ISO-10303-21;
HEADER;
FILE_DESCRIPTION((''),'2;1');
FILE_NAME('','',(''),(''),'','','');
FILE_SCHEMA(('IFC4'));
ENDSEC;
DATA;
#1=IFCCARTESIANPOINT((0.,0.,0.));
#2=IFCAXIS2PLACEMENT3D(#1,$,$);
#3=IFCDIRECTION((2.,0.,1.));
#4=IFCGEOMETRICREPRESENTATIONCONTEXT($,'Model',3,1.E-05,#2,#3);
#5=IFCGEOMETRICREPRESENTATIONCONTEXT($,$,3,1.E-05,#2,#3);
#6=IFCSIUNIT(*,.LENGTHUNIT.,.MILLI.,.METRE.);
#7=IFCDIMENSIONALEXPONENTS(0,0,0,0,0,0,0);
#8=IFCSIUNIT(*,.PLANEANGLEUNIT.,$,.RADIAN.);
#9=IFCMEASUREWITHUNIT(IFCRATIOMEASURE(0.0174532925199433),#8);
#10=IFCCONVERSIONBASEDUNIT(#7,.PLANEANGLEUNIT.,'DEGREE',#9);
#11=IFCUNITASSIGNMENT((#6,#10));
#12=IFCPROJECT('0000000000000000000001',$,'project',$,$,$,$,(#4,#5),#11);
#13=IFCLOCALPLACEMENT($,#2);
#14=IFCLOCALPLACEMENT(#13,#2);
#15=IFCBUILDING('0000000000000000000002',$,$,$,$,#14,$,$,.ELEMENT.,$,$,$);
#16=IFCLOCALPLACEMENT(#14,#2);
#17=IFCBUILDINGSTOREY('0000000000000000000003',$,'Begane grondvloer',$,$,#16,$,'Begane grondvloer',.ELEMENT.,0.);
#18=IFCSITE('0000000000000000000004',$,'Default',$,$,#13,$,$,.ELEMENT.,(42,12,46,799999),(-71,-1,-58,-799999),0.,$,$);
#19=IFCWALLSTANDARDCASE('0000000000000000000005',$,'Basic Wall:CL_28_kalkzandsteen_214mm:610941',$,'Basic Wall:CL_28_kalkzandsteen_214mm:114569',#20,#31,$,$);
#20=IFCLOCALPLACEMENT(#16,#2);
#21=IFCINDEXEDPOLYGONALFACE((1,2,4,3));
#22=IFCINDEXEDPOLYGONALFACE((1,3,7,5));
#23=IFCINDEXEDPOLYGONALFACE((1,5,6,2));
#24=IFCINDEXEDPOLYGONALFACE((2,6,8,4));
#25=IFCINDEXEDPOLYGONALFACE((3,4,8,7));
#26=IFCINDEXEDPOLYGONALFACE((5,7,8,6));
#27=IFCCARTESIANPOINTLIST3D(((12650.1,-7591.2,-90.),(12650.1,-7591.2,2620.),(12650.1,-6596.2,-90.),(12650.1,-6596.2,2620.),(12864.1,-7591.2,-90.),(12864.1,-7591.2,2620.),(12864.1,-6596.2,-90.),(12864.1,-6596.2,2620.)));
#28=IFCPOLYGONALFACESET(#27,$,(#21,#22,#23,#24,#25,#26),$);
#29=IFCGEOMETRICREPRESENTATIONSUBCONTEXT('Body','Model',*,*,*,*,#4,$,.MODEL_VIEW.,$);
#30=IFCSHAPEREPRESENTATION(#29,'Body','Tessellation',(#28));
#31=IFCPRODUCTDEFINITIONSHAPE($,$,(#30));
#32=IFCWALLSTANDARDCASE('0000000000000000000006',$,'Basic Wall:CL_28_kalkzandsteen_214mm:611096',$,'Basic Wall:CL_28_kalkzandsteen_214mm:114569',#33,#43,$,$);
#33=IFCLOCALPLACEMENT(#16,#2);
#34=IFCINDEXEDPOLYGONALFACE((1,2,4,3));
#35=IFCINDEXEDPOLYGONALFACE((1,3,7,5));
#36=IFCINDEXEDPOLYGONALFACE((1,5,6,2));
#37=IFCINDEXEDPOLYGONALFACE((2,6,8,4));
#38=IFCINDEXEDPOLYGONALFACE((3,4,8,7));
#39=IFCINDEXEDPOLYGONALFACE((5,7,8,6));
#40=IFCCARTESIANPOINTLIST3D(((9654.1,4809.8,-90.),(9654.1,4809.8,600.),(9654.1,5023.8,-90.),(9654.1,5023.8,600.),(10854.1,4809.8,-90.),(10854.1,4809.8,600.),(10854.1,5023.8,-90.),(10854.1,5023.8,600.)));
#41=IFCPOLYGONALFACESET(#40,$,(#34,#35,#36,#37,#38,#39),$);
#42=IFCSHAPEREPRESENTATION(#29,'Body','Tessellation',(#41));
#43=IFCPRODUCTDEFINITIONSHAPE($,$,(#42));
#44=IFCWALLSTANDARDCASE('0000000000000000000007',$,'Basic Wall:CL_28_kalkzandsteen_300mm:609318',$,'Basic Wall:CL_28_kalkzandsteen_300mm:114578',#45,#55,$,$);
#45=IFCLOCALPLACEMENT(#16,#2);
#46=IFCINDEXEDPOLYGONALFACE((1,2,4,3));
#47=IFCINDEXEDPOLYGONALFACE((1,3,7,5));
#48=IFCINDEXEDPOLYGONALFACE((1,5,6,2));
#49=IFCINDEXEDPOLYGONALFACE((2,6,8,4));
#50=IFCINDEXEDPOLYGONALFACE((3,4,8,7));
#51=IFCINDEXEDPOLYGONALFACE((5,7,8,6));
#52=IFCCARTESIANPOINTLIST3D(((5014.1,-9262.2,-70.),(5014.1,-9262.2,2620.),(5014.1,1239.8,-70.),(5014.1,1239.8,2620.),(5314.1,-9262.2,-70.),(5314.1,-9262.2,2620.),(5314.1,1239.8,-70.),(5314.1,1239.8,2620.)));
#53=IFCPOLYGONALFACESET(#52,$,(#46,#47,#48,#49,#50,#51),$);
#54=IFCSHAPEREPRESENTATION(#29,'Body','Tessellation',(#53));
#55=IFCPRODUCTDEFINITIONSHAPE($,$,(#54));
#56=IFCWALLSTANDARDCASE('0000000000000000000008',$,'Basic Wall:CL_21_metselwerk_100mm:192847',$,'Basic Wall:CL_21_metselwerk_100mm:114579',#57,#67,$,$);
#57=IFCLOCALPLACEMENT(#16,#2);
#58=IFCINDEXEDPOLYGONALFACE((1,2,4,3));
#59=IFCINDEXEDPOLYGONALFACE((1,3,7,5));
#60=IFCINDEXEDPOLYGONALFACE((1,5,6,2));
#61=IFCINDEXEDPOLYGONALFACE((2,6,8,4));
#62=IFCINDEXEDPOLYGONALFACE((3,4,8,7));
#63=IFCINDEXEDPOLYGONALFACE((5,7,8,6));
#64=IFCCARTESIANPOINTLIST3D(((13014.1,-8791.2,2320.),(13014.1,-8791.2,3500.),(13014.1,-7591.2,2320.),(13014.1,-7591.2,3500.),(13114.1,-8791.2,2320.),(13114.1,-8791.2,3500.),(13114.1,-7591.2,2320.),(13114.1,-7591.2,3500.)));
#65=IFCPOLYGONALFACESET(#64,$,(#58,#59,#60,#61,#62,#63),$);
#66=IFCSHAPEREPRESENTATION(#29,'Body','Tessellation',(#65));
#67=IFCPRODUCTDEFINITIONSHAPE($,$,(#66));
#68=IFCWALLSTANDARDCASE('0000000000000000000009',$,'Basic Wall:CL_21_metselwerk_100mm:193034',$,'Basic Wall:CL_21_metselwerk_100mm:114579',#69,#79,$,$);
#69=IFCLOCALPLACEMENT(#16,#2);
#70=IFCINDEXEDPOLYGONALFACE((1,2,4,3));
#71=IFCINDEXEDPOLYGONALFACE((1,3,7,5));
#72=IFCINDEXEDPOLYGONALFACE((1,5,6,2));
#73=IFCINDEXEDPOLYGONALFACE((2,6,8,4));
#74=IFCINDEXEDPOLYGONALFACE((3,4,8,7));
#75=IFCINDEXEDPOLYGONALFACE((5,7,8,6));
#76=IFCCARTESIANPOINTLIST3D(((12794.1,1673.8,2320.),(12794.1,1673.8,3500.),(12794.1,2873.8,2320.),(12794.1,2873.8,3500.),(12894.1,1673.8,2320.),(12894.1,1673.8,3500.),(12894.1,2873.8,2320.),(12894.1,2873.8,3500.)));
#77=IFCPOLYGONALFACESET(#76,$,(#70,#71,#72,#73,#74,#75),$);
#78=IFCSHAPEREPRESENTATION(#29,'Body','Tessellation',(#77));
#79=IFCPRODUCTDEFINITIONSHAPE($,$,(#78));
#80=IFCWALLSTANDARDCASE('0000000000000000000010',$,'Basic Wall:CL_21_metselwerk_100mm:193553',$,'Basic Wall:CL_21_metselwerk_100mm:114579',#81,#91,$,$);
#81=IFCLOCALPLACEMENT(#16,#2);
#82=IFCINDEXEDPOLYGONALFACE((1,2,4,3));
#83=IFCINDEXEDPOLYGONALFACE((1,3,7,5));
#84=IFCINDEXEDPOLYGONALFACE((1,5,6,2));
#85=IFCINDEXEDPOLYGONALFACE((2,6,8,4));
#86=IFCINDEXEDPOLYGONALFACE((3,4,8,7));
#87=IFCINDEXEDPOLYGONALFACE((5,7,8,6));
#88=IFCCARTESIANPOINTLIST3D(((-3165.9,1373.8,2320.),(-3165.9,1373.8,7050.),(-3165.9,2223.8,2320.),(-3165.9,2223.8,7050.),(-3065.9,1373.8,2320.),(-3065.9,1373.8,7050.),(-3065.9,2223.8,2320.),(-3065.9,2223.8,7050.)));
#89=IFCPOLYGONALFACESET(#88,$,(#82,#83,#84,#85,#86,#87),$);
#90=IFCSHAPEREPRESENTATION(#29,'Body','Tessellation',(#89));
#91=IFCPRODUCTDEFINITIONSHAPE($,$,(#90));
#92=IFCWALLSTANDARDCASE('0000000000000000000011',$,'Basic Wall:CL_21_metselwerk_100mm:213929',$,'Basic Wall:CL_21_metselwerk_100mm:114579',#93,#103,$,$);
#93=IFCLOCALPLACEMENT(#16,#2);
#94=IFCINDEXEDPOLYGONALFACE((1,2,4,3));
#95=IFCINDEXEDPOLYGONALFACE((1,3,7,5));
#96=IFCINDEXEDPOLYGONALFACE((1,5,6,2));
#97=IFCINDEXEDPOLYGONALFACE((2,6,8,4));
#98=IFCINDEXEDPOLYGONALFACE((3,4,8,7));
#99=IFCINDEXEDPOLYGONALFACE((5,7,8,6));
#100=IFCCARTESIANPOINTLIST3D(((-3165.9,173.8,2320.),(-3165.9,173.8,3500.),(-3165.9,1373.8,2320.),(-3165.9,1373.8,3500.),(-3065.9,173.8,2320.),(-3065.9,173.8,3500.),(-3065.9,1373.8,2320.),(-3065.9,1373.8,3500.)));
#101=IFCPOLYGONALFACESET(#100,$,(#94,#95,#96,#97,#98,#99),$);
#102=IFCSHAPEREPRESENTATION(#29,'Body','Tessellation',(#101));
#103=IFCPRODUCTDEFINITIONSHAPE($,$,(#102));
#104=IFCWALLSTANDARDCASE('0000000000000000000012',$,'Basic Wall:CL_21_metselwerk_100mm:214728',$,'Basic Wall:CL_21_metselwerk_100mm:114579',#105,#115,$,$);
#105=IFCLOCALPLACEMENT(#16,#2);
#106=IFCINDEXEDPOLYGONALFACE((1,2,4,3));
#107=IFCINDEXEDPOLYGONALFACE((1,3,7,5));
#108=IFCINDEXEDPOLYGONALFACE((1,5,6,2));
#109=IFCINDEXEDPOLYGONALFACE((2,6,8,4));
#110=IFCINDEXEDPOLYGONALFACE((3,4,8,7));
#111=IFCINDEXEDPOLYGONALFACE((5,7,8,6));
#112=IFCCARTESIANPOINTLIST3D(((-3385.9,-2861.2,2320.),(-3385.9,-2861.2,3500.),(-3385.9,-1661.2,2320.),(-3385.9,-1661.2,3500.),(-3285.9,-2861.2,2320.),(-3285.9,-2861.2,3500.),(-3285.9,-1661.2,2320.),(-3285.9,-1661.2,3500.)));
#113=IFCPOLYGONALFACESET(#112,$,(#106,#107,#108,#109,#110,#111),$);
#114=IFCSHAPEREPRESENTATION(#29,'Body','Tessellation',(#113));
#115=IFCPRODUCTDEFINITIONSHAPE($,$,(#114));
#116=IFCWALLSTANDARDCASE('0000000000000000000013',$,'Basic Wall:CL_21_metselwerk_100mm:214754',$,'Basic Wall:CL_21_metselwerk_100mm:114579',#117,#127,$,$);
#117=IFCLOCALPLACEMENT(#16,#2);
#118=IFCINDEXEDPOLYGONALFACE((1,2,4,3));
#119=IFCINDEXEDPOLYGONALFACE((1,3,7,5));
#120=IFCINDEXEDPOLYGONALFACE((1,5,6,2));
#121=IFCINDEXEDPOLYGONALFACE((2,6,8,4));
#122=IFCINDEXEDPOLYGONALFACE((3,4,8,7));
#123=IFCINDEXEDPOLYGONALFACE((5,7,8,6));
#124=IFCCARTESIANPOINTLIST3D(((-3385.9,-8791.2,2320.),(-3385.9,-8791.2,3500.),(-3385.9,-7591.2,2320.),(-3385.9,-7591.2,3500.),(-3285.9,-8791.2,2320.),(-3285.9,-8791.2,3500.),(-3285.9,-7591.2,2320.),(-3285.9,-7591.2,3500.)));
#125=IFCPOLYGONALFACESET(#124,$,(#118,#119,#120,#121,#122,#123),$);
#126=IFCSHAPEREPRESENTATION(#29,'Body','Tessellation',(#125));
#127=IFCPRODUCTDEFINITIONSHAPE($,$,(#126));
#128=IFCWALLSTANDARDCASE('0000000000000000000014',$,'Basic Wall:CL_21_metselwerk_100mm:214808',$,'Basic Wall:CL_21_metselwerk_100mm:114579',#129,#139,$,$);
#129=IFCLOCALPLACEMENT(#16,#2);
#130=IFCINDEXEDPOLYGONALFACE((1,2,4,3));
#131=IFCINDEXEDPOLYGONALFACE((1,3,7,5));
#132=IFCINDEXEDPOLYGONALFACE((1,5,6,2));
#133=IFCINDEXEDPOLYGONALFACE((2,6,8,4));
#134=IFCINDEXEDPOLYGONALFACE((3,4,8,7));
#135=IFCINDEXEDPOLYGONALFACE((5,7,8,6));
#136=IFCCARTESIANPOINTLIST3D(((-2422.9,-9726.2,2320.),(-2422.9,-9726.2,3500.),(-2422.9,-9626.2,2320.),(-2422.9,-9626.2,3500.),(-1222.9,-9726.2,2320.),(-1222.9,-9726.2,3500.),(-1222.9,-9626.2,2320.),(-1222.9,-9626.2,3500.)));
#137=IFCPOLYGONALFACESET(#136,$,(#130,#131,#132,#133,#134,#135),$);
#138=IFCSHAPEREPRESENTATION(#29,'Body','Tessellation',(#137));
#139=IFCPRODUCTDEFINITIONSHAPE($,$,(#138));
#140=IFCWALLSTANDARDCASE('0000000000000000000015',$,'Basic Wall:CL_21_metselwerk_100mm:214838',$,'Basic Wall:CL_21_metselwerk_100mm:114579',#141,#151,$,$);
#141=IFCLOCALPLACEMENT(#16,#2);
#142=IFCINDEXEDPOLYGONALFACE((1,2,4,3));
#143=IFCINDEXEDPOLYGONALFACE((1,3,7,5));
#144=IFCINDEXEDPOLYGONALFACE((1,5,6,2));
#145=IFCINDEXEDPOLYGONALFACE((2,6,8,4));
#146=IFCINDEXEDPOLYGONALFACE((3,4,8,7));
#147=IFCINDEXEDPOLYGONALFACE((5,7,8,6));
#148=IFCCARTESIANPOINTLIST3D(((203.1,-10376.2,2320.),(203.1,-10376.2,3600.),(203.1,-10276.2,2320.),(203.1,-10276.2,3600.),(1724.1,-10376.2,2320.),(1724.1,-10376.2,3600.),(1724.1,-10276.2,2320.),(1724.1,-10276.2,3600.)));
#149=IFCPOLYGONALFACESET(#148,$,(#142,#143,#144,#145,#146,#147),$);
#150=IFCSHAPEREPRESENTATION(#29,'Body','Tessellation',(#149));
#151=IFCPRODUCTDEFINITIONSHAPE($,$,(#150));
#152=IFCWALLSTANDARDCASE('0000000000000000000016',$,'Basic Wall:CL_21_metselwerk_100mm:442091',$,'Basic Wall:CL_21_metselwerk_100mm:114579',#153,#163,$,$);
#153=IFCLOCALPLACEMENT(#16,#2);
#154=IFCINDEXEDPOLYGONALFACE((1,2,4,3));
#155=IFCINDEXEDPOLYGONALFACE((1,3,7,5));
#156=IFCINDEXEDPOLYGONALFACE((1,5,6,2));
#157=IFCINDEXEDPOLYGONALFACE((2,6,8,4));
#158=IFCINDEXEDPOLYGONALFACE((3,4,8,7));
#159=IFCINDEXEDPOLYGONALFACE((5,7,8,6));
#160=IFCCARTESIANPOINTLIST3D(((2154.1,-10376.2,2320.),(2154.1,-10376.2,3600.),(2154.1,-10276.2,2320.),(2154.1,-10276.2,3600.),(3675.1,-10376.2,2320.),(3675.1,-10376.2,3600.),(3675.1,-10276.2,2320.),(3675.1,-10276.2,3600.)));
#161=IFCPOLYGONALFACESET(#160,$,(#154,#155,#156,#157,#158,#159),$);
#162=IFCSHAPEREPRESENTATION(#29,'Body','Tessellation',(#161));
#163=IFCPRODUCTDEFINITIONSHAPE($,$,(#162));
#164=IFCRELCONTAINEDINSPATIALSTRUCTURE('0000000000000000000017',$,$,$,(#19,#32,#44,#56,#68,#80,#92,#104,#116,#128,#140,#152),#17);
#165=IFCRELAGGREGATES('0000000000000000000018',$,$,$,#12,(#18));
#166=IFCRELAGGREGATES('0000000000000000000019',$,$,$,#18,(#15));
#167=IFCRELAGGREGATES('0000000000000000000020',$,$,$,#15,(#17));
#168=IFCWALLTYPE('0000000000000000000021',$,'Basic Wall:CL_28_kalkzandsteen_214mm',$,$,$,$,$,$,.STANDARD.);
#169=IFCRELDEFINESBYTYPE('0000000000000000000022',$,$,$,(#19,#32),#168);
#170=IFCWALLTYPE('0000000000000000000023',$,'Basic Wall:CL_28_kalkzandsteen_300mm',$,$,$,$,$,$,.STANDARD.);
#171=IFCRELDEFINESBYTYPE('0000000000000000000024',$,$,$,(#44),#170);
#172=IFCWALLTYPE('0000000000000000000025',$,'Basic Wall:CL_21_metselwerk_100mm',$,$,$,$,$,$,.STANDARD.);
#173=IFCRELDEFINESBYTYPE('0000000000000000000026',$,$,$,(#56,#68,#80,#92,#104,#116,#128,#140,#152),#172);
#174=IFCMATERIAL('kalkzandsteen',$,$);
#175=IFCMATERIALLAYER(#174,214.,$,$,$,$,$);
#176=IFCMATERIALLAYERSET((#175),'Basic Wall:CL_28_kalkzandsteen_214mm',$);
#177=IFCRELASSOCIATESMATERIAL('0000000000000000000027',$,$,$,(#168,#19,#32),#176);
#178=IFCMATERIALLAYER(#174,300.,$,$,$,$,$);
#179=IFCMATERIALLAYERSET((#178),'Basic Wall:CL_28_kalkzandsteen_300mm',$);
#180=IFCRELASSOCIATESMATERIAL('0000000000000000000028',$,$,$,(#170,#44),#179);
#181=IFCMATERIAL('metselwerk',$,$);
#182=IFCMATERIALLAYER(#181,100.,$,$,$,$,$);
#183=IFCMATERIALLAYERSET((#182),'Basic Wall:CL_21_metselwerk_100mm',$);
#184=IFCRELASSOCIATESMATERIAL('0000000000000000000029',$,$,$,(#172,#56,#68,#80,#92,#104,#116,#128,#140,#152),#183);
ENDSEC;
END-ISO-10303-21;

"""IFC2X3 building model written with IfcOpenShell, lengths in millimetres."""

from ifc_helpers import new_model, entity, si_unit, converted_unit, direction, frame, frame_2d, origin, place, context, subcontext, project, spatial, polyline, rectangle, extrude, clip, bounded_halfspace, material, layer, layer_set, layer_usage, type_object, element, save


model = new_model("IFC2X3")

# Units and contexts
model_context = context("Model", 3, precision=1e-05, world=origin(), true_north=direction((2.0, 0.0, 1.0)))
context_of_model = context(None, 3, precision=1e-05, world=origin(), true_north=direction((2.0, 0.0, 1.0)))
body_context = subcontext(model_context, "Body", "Model", "MODEL_VIEW")
ifc_project = project(units=[si_unit("LENGTHUNIT", "METRE", prefix="MILLI"), converted_unit("PLANEANGLEUNIT", "DEGREE", entity("IfcRatioMeasure", 0.0174532925199433), si_unit("PLANEANGLEUNIT", "RADIAN"), dimensions=[0, 0, 0, 0, 0, 0, 0])], contexts=[model_context, context_of_model])

# Site, building, storey
site_placement = place(None, origin())
site = spatial("IfcSite", under=ifc_project, at=site_placement, Name="Default", CompositionType="ELEMENT", RefLatitude=(42, 12, 46, 799999), RefLongitude=(-71, -1, -58, -799999), RefElevation=0.0)
building_placement = place(site_placement, origin())
building = spatial("IfcBuilding", under=site, at=building_placement, CompositionType="ELEMENT")
storey_placement = place(building_placement, origin())
storey = spatial("IfcBuildingStorey", under=building, at=storey_placement, Name="Begane grondvloer", LongName="Begane grondvloer", CompositionType="ELEMENT", Elevation=0.0)

# Walls
ifc_material_1 = material(Name="kalkzandsteen")
ifc_layer_1 = layer(ifc_material_1, 214.0)
ifc_layer_set_1 = layer_set([ifc_layer_1], Name="Basic Wall:CL_28_kalkzandsteen_214mm")
wall_type_1 = type_object("IfcWallType", Name="Basic Wall:CL_28_kalkzandsteen_214mm", PredefinedType="STANDARD", material=ifc_layer_set_1)
ifc_layer_usage_1 = layer_usage(ifc_layer_set_1, "AXIS2", "NEGATIVE", 107.0)
wall_1_placement = place(storey_placement, frame((12757.1, -7591.2, -90.0), z_axis=(0.0, 0.0, 1.0), x_axis=(0.0, 1.0, 0.0)))
element("IfcWallStandardCase", 1, at=wall_1_placement, inside=storey, type_object=wall_type_1, material=ifc_layer_usage_1, Name="Basic Wall:CL_28_kalkzandsteen_214mm:610941", ObjectType="Basic Wall:CL_28_kalkzandsteen_214mm:114569", context=body_context, shape_type="Clipping", body=[
    clip(clip(extrude(rectangle(XDim=995.0, YDim=214.0, at=frame_2d((497.5, 0.0), x_axis=(-1.0, 0.0))), origin(), (0.0, 0.0, 1.0), 2710.0), bounded_halfspace(frame((0.0, -107.0, 2710.0), z_axis=(0.0, 0.0, -1.0), x_axis=(0.0, -1.0, 0.0)), True, frame((0.0, -107.0, 2710.0)), polyline([(0.0, 0.0), (995.0, 0.0), (995.0, 214.0), (0.0, 214.0), (0.0, 0.0)]))), bounded_halfspace(frame((995.0, -107.0, 0.0)), True, frame((995.0, -107.0, 0.0)), polyline([(0.0, 0.0), (0.0, 214.0), (-995.0, 214.0), (-995.0, 0.0), (0.0, 0.0)]))),
])
ifc_layer_usage_2 = layer_usage(ifc_layer_set_1, "AXIS2", "NEGATIVE", 107.0)
wall_2_placement = place(storey_placement, frame((9654.1, 4916.8, -90.0)))
element("IfcWallStandardCase", 2, at=wall_2_placement, inside=storey, type_object=wall_type_1, material=ifc_layer_usage_2, Name="Basic Wall:CL_28_kalkzandsteen_214mm:611096", ObjectType="Basic Wall:CL_28_kalkzandsteen_214mm:114569", context=body_context, shape_type="Clipping", body=[
    clip(extrude(rectangle(XDim=1200.0, YDim=214.0, at=frame_2d((600.0, 0.0), x_axis=(-1.0, 0.0))), origin(), (0.0, 0.0, 1.0), 690.0), bounded_halfspace(frame((1200.0, -107.0, 0.0), z_axis=(0.0, 0.0, 1.0), x_axis=(0.0, 1.0, 0.0)), True, frame((1200.0, -107.0, 0.0)), polyline([(0.0, 0.0), (0.0, 214.0), (-1200.0, 214.0), (-1200.0, 0.0), (0.0, 0.0)]))),
])
ifc_layer_2 = layer(ifc_material_1, 300.0)
ifc_layer_set_2 = layer_set([ifc_layer_2], Name="Basic Wall:CL_28_kalkzandsteen_300mm")
ifc_layer_usage_3 = layer_usage(ifc_layer_set_2, "AXIS2", "NEGATIVE", 150.0)
wall_type_2 = type_object("IfcWallType", Name="Basic Wall:CL_28_kalkzandsteen_300mm", PredefinedType="STANDARD", material=ifc_layer_set_2)
wall_3_placement = place(storey_placement, frame((5164.1, 1239.8, -70.0), z_axis=(0.0, 0.0, 1.0), x_axis=(0.0, -1.0, 0.0)))
element("IfcWallStandardCase", 3, at=wall_3_placement, inside=storey, type_object=wall_type_2, material=ifc_layer_usage_3, Name="Basic Wall:CL_28_kalkzandsteen_300mm:609318", ObjectType="Basic Wall:CL_28_kalkzandsteen_300mm:114578", context=body_context, shape_type="Clipping", body=[
    clip(extrude(rectangle(XDim=10502.0, YDim=300.0, at=frame_2d((5251.0, 0.0), x_axis=(-1.0, 0.0))), origin(), (0.0, 0.0, 1.0), 2690.0), bounded_halfspace(frame((0.0, -150.0, 2690.0), z_axis=(0.0, 0.0, -1.0), x_axis=(0.0, 1.0, 0.0)), True, frame((0.0, -150.0, 2690.0)), polyline([(0.0, 0.0), (2932.1, 0.0), (4447.1, 0.0), (10502.0, 0.0), (10502.0, 300.0), (0.0, 300.0), (0.0, 0.0)]))),
])
ifc_material_2 = material(Name="metselwerk")
ifc_layer_3 = layer(ifc_material_2, 100.0)
ifc_layer_set_3 = layer_set([ifc_layer_3], Name="Basic Wall:CL_21_metselwerk_100mm")
ifc_layer_usage_4 = layer_usage(ifc_layer_set_3, "AXIS2", "NEGATIVE", 50.0)
wall_type_3 = type_object("IfcWallType", Name="Basic Wall:CL_21_metselwerk_100mm", PredefinedType="STANDARD", material=ifc_layer_set_3)
wall_4_placement = place(storey_placement, frame((13064.1, -8791.2, 2320.0), z_axis=(0.0, 0.0, 1.0), x_axis=(0.0, 1.0, 0.0)))
element("IfcWallStandardCase", 4, at=wall_4_placement, inside=storey, type_object=wall_type_3, material=ifc_layer_usage_4, Name="Basic Wall:CL_21_metselwerk_100mm:192847", ObjectType="Basic Wall:CL_21_metselwerk_100mm:114579", context=body_context, shape_type="SweptSolid", body=[
    extrude(rectangle(XDim=1200.0, YDim=100.0, at=frame_2d((600.0, 0.0), x_axis=(-1.0, 0.0))), origin(), (0.0, 0.0, 1.0), 1180.0),
])
ifc_layer_usage_5 = layer_usage(ifc_layer_set_3, "AXIS2", "NEGATIVE", 50.0)
wall_5_placement = place(storey_placement, frame((12844.1, 1673.8, 2320.0), z_axis=(0.0, 0.0, 1.0), x_axis=(0.0, 1.0, 0.0)))
element("IfcWallStandardCase", 5, at=wall_5_placement, inside=storey, type_object=wall_type_3, material=ifc_layer_usage_5, Name="Basic Wall:CL_21_metselwerk_100mm:193034", ObjectType="Basic Wall:CL_21_metselwerk_100mm:114579", context=body_context, shape_type="SweptSolid", body=[
    extrude(rectangle(XDim=1200.0, YDim=100.0, at=frame_2d((600.0, 0.0), x_axis=(-1.0, 0.0))), origin(), (0.0, 0.0, 1.0), 1180.0),
])
ifc_layer_usage_6 = layer_usage(ifc_layer_set_3, "AXIS2", "NEGATIVE", 50.0)
wall_6_placement = place(storey_placement, frame((-3115.9, 2223.8, 2320.0), z_axis=(0.0, 0.0, 1.0), x_axis=(0.0, -1.0, 0.0)))
element("IfcWallStandardCase", 6, at=wall_6_placement, inside=storey, type_object=wall_type_3, material=ifc_layer_usage_6, Name="Basic Wall:CL_21_metselwerk_100mm:193553", ObjectType="Basic Wall:CL_21_metselwerk_100mm:114579", context=body_context, shape_type="SweptSolid", body=[
    extrude(rectangle(XDim=850.0, YDim=100.0, at=frame_2d((425.0, 0.0), x_axis=(-1.0, 0.0))), origin(), (0.0, 0.0, 1.0), 4730.0),
])
ifc_layer_usage_7 = layer_usage(ifc_layer_set_3, "AXIS2", "NEGATIVE", 50.0)
wall_7_placement = place(storey_placement, frame((-3115.9, 1373.8, 2320.0), z_axis=(0.0, 0.0, 1.0), x_axis=(0.0, -1.0, 0.0)))
element("IfcWallStandardCase", 7, at=wall_7_placement, inside=storey, type_object=wall_type_3, material=ifc_layer_usage_7, Name="Basic Wall:CL_21_metselwerk_100mm:213929", ObjectType="Basic Wall:CL_21_metselwerk_100mm:114579", context=body_context, shape_type="SweptSolid", body=[
    extrude(rectangle(XDim=1200.0, YDim=100.0, at=frame_2d((600.0, 0.0), x_axis=(-1.0, 0.0))), origin(), (0.0, 0.0, 1.0), 1180.0),
])
ifc_layer_usage_8 = layer_usage(ifc_layer_set_3, "AXIS2", "NEGATIVE", 50.0)
wall_8_placement = place(storey_placement, frame((-3335.9, -1661.2, 2320.0), z_axis=(0.0, 0.0, 1.0), x_axis=(0.0, -1.0, 0.0)))
element("IfcWallStandardCase", 8, at=wall_8_placement, inside=storey, type_object=wall_type_3, material=ifc_layer_usage_8, Name="Basic Wall:CL_21_metselwerk_100mm:214728", ObjectType="Basic Wall:CL_21_metselwerk_100mm:114579", context=body_context, shape_type="SweptSolid", body=[
    extrude(rectangle(XDim=1200.0, YDim=100.0, at=frame_2d((600.0, 0.0), x_axis=(-1.0, 0.0))), origin(), (0.0, 0.0, 1.0), 1180.0),
])
ifc_layer_usage_9 = layer_usage(ifc_layer_set_3, "AXIS2", "NEGATIVE", 50.0)
wall_9_placement = place(storey_placement, frame((-3335.9, -7591.2, 2320.0), z_axis=(0.0, 0.0, 1.0), x_axis=(0.0, -1.0, 0.0)))
element("IfcWallStandardCase", 9, at=wall_9_placement, inside=storey, type_object=wall_type_3, material=ifc_layer_usage_9, Name="Basic Wall:CL_21_metselwerk_100mm:214754", ObjectType="Basic Wall:CL_21_metselwerk_100mm:114579", context=body_context, shape_type="SweptSolid", body=[
    extrude(rectangle(XDim=1200.0, YDim=100.0, at=frame_2d((600.0, 0.0), x_axis=(-1.0, 0.0))), origin(), (0.0, 0.0, 1.0), 1180.0),
])
ifc_layer_usage_10 = layer_usage(ifc_layer_set_3, "AXIS2", "NEGATIVE", 50.0)
wall_10_placement = place(storey_placement, frame((-2422.9, -9676.2, 2320.0)))
element("IfcWallStandardCase", 10, at=wall_10_placement, inside=storey, type_object=wall_type_3, material=ifc_layer_usage_10, Name="Basic Wall:CL_21_metselwerk_100mm:214808", ObjectType="Basic Wall:CL_21_metselwerk_100mm:114579", context=body_context, shape_type="SweptSolid", body=[
    extrude(rectangle(XDim=1200.0, YDim=100.0, at=frame_2d((600.0, 0.0), x_axis=(-1.0, 0.0))), origin(), (0.0, 0.0, 1.0), 1180.0),
])
ifc_layer_usage_11 = layer_usage(ifc_layer_set_3, "AXIS2", "NEGATIVE", 50.0)
wall_11_placement = place(storey_placement, frame((203.1, -10326.2, 2320.0)))
element("IfcWallStandardCase", 11, at=wall_11_placement, inside=storey, type_object=wall_type_3, material=ifc_layer_usage_11, Name="Basic Wall:CL_21_metselwerk_100mm:214838", ObjectType="Basic Wall:CL_21_metselwerk_100mm:114579", context=body_context, shape_type="SweptSolid", body=[
    extrude(rectangle(XDim=1521.0, YDim=100.0, at=frame_2d((760.5, 0.0), x_axis=(-1.0, 0.0))), origin(), (0.0, 0.0, 1.0), 1280.0),
])
ifc_layer_usage_12 = layer_usage(ifc_layer_set_3, "AXIS2", "NEGATIVE", 50.0)
wall_12_placement = place(storey_placement, frame((2154.1, -10326.2, 2320.0)))
element("IfcWallStandardCase", 12, at=wall_12_placement, inside=storey, type_object=wall_type_3, material=ifc_layer_usage_12, Name="Basic Wall:CL_21_metselwerk_100mm:442091", ObjectType="Basic Wall:CL_21_metselwerk_100mm:114579", context=body_context, shape_type="SweptSolid", body=[
    extrude(rectangle(XDim=1521.0, YDim=100.0, at=frame_2d((760.5, 0.0), x_axis=(-1.0, 0.0))), origin(), (0.0, 0.0, 1.0), 1280.0),
])

save(model, "model.ifc")
